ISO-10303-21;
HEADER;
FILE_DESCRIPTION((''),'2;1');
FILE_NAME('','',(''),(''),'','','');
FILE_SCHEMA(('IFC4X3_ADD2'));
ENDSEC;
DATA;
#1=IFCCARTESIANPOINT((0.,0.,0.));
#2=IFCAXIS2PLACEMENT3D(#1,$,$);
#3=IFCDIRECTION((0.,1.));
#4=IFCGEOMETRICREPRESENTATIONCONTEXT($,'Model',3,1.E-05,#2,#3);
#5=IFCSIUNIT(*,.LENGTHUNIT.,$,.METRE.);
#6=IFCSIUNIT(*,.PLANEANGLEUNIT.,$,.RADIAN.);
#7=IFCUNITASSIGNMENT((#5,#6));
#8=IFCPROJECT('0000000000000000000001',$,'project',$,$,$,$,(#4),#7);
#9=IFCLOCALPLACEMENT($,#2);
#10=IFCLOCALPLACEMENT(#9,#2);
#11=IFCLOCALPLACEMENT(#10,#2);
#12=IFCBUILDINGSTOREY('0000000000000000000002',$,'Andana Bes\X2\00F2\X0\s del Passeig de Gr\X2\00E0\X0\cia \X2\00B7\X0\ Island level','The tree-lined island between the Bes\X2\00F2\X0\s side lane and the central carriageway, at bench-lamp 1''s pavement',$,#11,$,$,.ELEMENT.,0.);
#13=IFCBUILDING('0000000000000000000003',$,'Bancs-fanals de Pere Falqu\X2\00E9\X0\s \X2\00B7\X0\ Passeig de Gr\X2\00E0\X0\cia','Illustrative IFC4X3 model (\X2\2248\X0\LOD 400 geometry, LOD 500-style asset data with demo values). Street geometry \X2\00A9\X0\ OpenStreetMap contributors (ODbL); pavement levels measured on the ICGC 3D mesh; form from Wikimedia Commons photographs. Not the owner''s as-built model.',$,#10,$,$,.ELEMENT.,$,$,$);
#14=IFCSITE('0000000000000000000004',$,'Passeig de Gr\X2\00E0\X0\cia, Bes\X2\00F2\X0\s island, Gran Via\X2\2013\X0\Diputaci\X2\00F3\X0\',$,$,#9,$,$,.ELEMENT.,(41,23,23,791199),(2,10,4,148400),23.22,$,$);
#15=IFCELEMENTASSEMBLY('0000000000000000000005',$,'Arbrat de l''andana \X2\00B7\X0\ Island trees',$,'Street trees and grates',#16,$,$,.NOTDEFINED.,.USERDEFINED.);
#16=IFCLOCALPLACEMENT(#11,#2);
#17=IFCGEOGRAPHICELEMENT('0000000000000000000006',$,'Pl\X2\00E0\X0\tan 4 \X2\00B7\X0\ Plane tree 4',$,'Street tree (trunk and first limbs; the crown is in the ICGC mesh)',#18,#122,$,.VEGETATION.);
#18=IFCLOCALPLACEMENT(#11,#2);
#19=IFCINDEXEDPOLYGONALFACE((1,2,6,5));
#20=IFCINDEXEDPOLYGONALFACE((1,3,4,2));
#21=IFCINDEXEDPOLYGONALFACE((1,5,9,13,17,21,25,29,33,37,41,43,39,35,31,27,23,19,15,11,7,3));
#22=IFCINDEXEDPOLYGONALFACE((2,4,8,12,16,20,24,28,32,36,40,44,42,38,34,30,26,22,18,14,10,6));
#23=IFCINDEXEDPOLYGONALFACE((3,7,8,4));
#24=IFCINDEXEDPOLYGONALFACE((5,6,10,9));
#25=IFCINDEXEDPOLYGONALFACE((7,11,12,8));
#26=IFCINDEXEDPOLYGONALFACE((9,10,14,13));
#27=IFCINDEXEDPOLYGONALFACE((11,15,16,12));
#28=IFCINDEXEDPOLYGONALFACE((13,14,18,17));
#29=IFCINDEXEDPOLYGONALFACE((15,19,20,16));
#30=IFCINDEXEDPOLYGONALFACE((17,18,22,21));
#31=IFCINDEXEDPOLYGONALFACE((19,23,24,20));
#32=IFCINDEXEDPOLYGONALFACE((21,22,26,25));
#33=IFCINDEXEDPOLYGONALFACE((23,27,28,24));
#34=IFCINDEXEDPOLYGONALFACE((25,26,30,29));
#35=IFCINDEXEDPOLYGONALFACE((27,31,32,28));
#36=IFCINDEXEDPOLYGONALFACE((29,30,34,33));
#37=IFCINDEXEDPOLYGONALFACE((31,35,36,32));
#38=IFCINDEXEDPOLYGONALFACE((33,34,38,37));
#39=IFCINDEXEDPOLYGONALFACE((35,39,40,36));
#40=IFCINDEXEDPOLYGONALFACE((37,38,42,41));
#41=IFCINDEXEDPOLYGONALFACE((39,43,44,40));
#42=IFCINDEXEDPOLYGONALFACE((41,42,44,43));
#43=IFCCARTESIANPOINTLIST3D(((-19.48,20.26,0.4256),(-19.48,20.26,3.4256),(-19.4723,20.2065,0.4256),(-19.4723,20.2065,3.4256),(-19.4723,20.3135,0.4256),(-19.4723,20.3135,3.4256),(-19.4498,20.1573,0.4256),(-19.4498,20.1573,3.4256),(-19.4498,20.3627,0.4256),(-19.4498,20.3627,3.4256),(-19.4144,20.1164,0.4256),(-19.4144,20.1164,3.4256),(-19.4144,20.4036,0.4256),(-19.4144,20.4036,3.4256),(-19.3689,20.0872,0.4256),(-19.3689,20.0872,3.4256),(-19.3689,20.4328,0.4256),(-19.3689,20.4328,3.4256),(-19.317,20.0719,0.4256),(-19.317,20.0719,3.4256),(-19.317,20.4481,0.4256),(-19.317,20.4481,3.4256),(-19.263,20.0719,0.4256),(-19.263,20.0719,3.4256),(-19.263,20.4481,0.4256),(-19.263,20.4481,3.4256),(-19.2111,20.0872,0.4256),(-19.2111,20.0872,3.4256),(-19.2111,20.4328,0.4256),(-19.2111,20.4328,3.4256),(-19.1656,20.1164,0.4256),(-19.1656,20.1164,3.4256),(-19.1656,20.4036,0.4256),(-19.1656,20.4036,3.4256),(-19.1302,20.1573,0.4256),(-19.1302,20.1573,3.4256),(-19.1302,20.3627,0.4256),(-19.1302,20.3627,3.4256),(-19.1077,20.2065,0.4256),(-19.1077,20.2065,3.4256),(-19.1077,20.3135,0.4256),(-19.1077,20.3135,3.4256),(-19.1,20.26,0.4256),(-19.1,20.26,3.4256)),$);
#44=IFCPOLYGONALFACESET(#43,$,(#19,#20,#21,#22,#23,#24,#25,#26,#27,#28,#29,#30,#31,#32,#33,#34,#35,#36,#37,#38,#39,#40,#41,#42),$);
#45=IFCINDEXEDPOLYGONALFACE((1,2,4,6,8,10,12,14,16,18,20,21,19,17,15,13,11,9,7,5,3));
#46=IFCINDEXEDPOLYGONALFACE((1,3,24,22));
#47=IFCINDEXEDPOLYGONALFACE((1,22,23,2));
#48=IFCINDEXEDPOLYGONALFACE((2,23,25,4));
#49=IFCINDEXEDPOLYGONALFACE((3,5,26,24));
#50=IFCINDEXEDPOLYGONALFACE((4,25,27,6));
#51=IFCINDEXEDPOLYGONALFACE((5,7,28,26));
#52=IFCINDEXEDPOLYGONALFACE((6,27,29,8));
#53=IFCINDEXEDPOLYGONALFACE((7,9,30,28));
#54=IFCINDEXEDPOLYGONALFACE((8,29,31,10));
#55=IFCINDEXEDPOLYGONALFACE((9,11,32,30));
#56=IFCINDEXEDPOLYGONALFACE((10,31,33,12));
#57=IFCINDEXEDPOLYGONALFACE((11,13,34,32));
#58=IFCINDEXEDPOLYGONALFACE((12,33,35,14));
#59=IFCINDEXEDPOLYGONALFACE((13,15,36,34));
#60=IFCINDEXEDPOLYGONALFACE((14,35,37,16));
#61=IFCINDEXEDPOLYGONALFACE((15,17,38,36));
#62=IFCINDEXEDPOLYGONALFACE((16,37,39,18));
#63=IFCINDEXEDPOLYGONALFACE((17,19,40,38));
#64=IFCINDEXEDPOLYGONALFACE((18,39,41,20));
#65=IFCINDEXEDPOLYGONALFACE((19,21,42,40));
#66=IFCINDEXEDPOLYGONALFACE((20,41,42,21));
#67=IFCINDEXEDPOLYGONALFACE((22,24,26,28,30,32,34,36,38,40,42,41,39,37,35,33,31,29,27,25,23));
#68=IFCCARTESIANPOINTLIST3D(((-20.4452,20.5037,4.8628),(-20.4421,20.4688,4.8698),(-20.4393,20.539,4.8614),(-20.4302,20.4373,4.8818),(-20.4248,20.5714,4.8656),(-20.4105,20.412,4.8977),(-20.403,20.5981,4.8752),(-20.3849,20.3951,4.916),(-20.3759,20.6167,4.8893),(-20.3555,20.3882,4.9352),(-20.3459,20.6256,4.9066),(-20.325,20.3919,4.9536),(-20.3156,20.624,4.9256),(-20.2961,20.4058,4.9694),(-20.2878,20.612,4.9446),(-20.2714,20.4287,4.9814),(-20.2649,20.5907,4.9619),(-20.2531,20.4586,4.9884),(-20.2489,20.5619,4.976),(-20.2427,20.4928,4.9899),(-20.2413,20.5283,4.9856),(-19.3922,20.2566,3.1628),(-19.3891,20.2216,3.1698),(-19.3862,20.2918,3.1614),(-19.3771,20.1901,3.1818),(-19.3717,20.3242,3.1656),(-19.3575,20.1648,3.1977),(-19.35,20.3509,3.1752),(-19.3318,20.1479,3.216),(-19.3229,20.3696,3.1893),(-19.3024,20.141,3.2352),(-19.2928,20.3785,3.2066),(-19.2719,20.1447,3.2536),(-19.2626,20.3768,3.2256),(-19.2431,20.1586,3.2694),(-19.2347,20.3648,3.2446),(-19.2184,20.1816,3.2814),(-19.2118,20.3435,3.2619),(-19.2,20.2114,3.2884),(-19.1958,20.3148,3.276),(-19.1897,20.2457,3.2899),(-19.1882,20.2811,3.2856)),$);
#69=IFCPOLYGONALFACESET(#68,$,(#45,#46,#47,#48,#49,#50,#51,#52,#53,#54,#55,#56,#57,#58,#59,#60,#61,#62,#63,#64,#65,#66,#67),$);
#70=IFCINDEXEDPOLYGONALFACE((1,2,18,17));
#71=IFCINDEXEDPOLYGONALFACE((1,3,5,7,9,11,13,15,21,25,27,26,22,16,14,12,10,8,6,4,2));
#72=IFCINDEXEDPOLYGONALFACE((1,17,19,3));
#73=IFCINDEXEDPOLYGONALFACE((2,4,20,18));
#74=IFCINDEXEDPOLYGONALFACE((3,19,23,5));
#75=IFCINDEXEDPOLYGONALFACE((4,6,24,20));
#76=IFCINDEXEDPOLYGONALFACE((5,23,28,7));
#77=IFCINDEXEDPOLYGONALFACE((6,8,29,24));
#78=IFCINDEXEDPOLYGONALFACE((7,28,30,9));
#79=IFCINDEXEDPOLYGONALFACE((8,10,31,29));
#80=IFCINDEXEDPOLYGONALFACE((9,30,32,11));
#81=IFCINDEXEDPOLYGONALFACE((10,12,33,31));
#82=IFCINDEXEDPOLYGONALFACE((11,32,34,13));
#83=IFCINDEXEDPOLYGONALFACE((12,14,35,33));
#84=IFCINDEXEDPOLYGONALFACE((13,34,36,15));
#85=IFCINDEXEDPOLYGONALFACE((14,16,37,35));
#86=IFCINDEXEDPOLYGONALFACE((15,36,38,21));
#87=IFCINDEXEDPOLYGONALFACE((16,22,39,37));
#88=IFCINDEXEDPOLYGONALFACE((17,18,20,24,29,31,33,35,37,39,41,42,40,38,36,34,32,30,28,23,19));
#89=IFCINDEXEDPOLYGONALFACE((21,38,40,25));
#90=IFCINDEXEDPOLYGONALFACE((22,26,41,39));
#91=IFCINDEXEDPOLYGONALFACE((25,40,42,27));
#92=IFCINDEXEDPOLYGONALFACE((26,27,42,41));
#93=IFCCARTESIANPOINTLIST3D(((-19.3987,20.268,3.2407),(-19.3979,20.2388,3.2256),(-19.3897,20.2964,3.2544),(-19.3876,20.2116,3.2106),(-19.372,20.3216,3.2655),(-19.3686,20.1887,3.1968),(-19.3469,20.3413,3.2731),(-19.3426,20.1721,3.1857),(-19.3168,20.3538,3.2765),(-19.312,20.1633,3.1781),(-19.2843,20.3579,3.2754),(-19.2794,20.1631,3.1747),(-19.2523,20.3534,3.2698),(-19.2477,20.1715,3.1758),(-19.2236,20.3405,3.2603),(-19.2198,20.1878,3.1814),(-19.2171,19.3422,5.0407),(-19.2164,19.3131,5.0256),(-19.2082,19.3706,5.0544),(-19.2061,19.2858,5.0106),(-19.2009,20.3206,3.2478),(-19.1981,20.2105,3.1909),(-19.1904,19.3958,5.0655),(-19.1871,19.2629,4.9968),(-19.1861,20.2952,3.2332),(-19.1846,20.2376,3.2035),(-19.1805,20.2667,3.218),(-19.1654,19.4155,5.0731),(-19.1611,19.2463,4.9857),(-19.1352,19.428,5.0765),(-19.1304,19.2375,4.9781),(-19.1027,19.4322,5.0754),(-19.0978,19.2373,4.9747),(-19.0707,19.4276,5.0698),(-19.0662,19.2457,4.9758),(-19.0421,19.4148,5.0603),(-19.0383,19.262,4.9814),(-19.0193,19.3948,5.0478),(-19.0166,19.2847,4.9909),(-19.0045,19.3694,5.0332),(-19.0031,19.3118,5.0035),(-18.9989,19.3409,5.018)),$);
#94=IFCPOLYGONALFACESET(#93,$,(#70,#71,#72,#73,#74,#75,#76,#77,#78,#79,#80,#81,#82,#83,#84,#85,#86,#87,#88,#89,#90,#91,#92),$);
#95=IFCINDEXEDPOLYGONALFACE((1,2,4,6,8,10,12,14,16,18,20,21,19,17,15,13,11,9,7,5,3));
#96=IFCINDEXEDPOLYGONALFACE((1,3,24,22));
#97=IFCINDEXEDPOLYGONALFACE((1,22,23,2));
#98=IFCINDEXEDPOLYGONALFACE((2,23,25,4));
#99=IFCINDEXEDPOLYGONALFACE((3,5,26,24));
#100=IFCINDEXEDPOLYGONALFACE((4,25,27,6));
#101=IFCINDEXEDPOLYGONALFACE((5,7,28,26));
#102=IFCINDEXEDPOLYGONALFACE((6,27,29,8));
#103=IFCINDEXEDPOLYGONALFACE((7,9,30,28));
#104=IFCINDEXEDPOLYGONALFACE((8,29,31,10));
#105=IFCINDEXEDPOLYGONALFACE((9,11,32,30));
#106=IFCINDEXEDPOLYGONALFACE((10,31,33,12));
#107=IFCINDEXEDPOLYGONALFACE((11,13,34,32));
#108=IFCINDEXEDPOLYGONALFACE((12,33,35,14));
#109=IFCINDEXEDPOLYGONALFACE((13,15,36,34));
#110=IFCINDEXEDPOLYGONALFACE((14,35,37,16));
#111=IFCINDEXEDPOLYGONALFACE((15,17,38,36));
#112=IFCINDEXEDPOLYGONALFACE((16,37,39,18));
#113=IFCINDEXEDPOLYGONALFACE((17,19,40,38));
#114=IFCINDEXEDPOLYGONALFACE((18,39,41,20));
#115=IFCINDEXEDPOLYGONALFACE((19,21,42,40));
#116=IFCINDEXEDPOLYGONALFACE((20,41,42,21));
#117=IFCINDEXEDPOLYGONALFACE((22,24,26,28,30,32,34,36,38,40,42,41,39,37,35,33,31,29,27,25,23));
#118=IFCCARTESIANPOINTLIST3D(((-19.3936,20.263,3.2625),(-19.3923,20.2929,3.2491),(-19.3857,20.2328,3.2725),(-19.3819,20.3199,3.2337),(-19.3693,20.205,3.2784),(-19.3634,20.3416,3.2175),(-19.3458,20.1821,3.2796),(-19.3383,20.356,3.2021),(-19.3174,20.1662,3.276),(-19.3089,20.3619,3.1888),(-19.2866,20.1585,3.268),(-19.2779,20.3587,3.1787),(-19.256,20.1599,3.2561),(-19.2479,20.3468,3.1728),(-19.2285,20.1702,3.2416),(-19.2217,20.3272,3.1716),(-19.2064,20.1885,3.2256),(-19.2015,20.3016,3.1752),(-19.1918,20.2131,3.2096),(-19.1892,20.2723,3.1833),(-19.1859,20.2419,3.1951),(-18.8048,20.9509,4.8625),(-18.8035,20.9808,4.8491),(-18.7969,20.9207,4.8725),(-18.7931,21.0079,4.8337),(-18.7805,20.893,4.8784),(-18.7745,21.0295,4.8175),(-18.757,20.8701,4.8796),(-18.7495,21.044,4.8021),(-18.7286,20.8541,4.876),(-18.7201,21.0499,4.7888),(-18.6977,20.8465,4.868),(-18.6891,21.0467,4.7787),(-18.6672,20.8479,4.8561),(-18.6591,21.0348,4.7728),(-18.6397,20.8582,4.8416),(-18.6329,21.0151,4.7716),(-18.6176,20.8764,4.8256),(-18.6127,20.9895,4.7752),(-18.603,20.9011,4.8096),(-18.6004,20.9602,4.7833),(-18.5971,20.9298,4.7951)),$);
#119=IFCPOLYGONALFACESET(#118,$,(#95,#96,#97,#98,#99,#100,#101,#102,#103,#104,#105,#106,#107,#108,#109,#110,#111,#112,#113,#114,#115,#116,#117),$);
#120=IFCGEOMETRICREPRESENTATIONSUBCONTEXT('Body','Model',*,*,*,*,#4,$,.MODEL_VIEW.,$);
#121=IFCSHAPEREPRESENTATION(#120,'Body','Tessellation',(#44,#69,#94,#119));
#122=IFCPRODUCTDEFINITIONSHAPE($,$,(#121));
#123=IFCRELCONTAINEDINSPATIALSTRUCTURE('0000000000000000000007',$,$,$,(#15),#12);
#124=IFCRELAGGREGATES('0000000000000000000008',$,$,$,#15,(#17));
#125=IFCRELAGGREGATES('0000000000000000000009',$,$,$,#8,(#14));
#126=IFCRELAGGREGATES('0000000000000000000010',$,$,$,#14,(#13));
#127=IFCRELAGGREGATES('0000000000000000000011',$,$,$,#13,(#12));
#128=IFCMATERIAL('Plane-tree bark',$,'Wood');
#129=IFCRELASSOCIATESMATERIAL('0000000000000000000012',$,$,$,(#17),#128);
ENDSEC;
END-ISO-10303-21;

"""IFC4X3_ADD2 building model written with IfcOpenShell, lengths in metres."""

from ifc_helpers import new_model, si_unit, direction, frame, origin, origin_2d_with_axis, place, context, subcontext, project, spatial, circle, extrude, material, element, aggregate, save


model = new_model("IFC4X3_ADD2")

# Units and contexts
model_context = context("Model", 3, precision=1e-05, world=origin(), true_north=direction((0.0, 1.0)))
body_context = subcontext(model_context, "Body", "Model", "MODEL_VIEW")
ifc_project = project(units=[si_unit("LENGTHUNIT", "METRE"), si_unit("PLANEANGLEUNIT", "RADIAN")], contexts=[model_context])

# Site, building, storey
site_placement = place(None, origin())
site = spatial("IfcSite", under=ifc_project, at=site_placement, Name="Passeig de Gràcia, Besòs island, Gran Via–Diputació", CompositionType="ELEMENT", RefLatitude=(41, 23, 23, 791199), RefLongitude=(2, 10, 4, 148400), RefElevation=23.22)
building_placement = place(site_placement, origin())
building = spatial("IfcBuilding", under=site, at=building_placement, Name="Bancs-fanals de Pere Falqués · Passeig de Gràcia", Description="Illustrative IFC4X3 model (≈LOD 400 geometry, LOD 500-style asset data with demo values). Street geometry © OpenStreetMap contributors (ODbL); pavement levels measured on the ICGC 3D mesh; form from Wikimedia Commons photographs. Not the owner's as-built model.", CompositionType="ELEMENT")
storey_placement = place(building_placement, origin())
storey = spatial("IfcBuildingStorey", under=building, at=storey_placement, Name="Andana Besòs del Passeig de Gràcia · Island level", Description="The tree-lined island between the Besòs side lane and the central carriageway, at bench-lamp 1's pavement", CompositionType="ELEMENT", Elevation=0.0)

# Element assembly
assembly_1_placement = place(building_placement, origin())
assembly_1 = element("IfcElementAssembly", 1, at=assembly_1_placement, inside=storey, Name="Arbrat de l'andana · Island trees", ObjectType="Street trees and grates", AssemblyPlace="NOTDEFINED", PredefinedType="USERDEFINED")

# Geographic element
ifc_material_1 = material(Name="Plane-tree bark", Category="Wood")
geographic_element_1_placement = place(building_placement, origin())
geographic_element_1 = element("IfcGeographicElement", 2, at=geographic_element_1_placement, material=ifc_material_1, Name="Plàtan 4 · Plane tree 4", ObjectType="Street tree (trunk and first limbs; the crown is in the ICGC mesh)", PredefinedType="VEGETATION", context=body_context, shape_type="SweptSolid", body=[
    extrude(circle(Radius=0.19, at=origin_2d_with_axis()), frame((-19.29, 20.26, 0.4256)), (0.0, 0.0, 1.0), 3.0),
    extrude(circle(Radius=0.12, at=origin_2d_with_axis()), frame((-19.29, 20.26, 3.2256), z_axis=(-0.522617, 0.122674, 0.843696), x_axis=(0.22852, 0.973539, 0.0)), (0.0, 0.0, 1.0), 2.0149),
    extrude(circle(Radius=0.11, at=origin_2d_with_axis()), frame((-19.29, 20.26, 3.2256), z_axis=(0.089329, -0.45554, 0.885722), x_axis=(-0.981311, -0.19243, 0.0)), (0.0, 0.0, 1.0), 2.0322),
    extrude(circle(Radius=0.11, at=origin_2d_with_axis()), frame((-19.29, 20.26, 3.2256), z_axis=(0.320275, 0.374202, 0.870285), x_axis=(0.759728, -0.650241, 0.0)), (0.0, 0.0, 1.0), 1.8385),
])
aggregate(assembly_1, [geographic_element_1])

save(model, "model.ifc")
